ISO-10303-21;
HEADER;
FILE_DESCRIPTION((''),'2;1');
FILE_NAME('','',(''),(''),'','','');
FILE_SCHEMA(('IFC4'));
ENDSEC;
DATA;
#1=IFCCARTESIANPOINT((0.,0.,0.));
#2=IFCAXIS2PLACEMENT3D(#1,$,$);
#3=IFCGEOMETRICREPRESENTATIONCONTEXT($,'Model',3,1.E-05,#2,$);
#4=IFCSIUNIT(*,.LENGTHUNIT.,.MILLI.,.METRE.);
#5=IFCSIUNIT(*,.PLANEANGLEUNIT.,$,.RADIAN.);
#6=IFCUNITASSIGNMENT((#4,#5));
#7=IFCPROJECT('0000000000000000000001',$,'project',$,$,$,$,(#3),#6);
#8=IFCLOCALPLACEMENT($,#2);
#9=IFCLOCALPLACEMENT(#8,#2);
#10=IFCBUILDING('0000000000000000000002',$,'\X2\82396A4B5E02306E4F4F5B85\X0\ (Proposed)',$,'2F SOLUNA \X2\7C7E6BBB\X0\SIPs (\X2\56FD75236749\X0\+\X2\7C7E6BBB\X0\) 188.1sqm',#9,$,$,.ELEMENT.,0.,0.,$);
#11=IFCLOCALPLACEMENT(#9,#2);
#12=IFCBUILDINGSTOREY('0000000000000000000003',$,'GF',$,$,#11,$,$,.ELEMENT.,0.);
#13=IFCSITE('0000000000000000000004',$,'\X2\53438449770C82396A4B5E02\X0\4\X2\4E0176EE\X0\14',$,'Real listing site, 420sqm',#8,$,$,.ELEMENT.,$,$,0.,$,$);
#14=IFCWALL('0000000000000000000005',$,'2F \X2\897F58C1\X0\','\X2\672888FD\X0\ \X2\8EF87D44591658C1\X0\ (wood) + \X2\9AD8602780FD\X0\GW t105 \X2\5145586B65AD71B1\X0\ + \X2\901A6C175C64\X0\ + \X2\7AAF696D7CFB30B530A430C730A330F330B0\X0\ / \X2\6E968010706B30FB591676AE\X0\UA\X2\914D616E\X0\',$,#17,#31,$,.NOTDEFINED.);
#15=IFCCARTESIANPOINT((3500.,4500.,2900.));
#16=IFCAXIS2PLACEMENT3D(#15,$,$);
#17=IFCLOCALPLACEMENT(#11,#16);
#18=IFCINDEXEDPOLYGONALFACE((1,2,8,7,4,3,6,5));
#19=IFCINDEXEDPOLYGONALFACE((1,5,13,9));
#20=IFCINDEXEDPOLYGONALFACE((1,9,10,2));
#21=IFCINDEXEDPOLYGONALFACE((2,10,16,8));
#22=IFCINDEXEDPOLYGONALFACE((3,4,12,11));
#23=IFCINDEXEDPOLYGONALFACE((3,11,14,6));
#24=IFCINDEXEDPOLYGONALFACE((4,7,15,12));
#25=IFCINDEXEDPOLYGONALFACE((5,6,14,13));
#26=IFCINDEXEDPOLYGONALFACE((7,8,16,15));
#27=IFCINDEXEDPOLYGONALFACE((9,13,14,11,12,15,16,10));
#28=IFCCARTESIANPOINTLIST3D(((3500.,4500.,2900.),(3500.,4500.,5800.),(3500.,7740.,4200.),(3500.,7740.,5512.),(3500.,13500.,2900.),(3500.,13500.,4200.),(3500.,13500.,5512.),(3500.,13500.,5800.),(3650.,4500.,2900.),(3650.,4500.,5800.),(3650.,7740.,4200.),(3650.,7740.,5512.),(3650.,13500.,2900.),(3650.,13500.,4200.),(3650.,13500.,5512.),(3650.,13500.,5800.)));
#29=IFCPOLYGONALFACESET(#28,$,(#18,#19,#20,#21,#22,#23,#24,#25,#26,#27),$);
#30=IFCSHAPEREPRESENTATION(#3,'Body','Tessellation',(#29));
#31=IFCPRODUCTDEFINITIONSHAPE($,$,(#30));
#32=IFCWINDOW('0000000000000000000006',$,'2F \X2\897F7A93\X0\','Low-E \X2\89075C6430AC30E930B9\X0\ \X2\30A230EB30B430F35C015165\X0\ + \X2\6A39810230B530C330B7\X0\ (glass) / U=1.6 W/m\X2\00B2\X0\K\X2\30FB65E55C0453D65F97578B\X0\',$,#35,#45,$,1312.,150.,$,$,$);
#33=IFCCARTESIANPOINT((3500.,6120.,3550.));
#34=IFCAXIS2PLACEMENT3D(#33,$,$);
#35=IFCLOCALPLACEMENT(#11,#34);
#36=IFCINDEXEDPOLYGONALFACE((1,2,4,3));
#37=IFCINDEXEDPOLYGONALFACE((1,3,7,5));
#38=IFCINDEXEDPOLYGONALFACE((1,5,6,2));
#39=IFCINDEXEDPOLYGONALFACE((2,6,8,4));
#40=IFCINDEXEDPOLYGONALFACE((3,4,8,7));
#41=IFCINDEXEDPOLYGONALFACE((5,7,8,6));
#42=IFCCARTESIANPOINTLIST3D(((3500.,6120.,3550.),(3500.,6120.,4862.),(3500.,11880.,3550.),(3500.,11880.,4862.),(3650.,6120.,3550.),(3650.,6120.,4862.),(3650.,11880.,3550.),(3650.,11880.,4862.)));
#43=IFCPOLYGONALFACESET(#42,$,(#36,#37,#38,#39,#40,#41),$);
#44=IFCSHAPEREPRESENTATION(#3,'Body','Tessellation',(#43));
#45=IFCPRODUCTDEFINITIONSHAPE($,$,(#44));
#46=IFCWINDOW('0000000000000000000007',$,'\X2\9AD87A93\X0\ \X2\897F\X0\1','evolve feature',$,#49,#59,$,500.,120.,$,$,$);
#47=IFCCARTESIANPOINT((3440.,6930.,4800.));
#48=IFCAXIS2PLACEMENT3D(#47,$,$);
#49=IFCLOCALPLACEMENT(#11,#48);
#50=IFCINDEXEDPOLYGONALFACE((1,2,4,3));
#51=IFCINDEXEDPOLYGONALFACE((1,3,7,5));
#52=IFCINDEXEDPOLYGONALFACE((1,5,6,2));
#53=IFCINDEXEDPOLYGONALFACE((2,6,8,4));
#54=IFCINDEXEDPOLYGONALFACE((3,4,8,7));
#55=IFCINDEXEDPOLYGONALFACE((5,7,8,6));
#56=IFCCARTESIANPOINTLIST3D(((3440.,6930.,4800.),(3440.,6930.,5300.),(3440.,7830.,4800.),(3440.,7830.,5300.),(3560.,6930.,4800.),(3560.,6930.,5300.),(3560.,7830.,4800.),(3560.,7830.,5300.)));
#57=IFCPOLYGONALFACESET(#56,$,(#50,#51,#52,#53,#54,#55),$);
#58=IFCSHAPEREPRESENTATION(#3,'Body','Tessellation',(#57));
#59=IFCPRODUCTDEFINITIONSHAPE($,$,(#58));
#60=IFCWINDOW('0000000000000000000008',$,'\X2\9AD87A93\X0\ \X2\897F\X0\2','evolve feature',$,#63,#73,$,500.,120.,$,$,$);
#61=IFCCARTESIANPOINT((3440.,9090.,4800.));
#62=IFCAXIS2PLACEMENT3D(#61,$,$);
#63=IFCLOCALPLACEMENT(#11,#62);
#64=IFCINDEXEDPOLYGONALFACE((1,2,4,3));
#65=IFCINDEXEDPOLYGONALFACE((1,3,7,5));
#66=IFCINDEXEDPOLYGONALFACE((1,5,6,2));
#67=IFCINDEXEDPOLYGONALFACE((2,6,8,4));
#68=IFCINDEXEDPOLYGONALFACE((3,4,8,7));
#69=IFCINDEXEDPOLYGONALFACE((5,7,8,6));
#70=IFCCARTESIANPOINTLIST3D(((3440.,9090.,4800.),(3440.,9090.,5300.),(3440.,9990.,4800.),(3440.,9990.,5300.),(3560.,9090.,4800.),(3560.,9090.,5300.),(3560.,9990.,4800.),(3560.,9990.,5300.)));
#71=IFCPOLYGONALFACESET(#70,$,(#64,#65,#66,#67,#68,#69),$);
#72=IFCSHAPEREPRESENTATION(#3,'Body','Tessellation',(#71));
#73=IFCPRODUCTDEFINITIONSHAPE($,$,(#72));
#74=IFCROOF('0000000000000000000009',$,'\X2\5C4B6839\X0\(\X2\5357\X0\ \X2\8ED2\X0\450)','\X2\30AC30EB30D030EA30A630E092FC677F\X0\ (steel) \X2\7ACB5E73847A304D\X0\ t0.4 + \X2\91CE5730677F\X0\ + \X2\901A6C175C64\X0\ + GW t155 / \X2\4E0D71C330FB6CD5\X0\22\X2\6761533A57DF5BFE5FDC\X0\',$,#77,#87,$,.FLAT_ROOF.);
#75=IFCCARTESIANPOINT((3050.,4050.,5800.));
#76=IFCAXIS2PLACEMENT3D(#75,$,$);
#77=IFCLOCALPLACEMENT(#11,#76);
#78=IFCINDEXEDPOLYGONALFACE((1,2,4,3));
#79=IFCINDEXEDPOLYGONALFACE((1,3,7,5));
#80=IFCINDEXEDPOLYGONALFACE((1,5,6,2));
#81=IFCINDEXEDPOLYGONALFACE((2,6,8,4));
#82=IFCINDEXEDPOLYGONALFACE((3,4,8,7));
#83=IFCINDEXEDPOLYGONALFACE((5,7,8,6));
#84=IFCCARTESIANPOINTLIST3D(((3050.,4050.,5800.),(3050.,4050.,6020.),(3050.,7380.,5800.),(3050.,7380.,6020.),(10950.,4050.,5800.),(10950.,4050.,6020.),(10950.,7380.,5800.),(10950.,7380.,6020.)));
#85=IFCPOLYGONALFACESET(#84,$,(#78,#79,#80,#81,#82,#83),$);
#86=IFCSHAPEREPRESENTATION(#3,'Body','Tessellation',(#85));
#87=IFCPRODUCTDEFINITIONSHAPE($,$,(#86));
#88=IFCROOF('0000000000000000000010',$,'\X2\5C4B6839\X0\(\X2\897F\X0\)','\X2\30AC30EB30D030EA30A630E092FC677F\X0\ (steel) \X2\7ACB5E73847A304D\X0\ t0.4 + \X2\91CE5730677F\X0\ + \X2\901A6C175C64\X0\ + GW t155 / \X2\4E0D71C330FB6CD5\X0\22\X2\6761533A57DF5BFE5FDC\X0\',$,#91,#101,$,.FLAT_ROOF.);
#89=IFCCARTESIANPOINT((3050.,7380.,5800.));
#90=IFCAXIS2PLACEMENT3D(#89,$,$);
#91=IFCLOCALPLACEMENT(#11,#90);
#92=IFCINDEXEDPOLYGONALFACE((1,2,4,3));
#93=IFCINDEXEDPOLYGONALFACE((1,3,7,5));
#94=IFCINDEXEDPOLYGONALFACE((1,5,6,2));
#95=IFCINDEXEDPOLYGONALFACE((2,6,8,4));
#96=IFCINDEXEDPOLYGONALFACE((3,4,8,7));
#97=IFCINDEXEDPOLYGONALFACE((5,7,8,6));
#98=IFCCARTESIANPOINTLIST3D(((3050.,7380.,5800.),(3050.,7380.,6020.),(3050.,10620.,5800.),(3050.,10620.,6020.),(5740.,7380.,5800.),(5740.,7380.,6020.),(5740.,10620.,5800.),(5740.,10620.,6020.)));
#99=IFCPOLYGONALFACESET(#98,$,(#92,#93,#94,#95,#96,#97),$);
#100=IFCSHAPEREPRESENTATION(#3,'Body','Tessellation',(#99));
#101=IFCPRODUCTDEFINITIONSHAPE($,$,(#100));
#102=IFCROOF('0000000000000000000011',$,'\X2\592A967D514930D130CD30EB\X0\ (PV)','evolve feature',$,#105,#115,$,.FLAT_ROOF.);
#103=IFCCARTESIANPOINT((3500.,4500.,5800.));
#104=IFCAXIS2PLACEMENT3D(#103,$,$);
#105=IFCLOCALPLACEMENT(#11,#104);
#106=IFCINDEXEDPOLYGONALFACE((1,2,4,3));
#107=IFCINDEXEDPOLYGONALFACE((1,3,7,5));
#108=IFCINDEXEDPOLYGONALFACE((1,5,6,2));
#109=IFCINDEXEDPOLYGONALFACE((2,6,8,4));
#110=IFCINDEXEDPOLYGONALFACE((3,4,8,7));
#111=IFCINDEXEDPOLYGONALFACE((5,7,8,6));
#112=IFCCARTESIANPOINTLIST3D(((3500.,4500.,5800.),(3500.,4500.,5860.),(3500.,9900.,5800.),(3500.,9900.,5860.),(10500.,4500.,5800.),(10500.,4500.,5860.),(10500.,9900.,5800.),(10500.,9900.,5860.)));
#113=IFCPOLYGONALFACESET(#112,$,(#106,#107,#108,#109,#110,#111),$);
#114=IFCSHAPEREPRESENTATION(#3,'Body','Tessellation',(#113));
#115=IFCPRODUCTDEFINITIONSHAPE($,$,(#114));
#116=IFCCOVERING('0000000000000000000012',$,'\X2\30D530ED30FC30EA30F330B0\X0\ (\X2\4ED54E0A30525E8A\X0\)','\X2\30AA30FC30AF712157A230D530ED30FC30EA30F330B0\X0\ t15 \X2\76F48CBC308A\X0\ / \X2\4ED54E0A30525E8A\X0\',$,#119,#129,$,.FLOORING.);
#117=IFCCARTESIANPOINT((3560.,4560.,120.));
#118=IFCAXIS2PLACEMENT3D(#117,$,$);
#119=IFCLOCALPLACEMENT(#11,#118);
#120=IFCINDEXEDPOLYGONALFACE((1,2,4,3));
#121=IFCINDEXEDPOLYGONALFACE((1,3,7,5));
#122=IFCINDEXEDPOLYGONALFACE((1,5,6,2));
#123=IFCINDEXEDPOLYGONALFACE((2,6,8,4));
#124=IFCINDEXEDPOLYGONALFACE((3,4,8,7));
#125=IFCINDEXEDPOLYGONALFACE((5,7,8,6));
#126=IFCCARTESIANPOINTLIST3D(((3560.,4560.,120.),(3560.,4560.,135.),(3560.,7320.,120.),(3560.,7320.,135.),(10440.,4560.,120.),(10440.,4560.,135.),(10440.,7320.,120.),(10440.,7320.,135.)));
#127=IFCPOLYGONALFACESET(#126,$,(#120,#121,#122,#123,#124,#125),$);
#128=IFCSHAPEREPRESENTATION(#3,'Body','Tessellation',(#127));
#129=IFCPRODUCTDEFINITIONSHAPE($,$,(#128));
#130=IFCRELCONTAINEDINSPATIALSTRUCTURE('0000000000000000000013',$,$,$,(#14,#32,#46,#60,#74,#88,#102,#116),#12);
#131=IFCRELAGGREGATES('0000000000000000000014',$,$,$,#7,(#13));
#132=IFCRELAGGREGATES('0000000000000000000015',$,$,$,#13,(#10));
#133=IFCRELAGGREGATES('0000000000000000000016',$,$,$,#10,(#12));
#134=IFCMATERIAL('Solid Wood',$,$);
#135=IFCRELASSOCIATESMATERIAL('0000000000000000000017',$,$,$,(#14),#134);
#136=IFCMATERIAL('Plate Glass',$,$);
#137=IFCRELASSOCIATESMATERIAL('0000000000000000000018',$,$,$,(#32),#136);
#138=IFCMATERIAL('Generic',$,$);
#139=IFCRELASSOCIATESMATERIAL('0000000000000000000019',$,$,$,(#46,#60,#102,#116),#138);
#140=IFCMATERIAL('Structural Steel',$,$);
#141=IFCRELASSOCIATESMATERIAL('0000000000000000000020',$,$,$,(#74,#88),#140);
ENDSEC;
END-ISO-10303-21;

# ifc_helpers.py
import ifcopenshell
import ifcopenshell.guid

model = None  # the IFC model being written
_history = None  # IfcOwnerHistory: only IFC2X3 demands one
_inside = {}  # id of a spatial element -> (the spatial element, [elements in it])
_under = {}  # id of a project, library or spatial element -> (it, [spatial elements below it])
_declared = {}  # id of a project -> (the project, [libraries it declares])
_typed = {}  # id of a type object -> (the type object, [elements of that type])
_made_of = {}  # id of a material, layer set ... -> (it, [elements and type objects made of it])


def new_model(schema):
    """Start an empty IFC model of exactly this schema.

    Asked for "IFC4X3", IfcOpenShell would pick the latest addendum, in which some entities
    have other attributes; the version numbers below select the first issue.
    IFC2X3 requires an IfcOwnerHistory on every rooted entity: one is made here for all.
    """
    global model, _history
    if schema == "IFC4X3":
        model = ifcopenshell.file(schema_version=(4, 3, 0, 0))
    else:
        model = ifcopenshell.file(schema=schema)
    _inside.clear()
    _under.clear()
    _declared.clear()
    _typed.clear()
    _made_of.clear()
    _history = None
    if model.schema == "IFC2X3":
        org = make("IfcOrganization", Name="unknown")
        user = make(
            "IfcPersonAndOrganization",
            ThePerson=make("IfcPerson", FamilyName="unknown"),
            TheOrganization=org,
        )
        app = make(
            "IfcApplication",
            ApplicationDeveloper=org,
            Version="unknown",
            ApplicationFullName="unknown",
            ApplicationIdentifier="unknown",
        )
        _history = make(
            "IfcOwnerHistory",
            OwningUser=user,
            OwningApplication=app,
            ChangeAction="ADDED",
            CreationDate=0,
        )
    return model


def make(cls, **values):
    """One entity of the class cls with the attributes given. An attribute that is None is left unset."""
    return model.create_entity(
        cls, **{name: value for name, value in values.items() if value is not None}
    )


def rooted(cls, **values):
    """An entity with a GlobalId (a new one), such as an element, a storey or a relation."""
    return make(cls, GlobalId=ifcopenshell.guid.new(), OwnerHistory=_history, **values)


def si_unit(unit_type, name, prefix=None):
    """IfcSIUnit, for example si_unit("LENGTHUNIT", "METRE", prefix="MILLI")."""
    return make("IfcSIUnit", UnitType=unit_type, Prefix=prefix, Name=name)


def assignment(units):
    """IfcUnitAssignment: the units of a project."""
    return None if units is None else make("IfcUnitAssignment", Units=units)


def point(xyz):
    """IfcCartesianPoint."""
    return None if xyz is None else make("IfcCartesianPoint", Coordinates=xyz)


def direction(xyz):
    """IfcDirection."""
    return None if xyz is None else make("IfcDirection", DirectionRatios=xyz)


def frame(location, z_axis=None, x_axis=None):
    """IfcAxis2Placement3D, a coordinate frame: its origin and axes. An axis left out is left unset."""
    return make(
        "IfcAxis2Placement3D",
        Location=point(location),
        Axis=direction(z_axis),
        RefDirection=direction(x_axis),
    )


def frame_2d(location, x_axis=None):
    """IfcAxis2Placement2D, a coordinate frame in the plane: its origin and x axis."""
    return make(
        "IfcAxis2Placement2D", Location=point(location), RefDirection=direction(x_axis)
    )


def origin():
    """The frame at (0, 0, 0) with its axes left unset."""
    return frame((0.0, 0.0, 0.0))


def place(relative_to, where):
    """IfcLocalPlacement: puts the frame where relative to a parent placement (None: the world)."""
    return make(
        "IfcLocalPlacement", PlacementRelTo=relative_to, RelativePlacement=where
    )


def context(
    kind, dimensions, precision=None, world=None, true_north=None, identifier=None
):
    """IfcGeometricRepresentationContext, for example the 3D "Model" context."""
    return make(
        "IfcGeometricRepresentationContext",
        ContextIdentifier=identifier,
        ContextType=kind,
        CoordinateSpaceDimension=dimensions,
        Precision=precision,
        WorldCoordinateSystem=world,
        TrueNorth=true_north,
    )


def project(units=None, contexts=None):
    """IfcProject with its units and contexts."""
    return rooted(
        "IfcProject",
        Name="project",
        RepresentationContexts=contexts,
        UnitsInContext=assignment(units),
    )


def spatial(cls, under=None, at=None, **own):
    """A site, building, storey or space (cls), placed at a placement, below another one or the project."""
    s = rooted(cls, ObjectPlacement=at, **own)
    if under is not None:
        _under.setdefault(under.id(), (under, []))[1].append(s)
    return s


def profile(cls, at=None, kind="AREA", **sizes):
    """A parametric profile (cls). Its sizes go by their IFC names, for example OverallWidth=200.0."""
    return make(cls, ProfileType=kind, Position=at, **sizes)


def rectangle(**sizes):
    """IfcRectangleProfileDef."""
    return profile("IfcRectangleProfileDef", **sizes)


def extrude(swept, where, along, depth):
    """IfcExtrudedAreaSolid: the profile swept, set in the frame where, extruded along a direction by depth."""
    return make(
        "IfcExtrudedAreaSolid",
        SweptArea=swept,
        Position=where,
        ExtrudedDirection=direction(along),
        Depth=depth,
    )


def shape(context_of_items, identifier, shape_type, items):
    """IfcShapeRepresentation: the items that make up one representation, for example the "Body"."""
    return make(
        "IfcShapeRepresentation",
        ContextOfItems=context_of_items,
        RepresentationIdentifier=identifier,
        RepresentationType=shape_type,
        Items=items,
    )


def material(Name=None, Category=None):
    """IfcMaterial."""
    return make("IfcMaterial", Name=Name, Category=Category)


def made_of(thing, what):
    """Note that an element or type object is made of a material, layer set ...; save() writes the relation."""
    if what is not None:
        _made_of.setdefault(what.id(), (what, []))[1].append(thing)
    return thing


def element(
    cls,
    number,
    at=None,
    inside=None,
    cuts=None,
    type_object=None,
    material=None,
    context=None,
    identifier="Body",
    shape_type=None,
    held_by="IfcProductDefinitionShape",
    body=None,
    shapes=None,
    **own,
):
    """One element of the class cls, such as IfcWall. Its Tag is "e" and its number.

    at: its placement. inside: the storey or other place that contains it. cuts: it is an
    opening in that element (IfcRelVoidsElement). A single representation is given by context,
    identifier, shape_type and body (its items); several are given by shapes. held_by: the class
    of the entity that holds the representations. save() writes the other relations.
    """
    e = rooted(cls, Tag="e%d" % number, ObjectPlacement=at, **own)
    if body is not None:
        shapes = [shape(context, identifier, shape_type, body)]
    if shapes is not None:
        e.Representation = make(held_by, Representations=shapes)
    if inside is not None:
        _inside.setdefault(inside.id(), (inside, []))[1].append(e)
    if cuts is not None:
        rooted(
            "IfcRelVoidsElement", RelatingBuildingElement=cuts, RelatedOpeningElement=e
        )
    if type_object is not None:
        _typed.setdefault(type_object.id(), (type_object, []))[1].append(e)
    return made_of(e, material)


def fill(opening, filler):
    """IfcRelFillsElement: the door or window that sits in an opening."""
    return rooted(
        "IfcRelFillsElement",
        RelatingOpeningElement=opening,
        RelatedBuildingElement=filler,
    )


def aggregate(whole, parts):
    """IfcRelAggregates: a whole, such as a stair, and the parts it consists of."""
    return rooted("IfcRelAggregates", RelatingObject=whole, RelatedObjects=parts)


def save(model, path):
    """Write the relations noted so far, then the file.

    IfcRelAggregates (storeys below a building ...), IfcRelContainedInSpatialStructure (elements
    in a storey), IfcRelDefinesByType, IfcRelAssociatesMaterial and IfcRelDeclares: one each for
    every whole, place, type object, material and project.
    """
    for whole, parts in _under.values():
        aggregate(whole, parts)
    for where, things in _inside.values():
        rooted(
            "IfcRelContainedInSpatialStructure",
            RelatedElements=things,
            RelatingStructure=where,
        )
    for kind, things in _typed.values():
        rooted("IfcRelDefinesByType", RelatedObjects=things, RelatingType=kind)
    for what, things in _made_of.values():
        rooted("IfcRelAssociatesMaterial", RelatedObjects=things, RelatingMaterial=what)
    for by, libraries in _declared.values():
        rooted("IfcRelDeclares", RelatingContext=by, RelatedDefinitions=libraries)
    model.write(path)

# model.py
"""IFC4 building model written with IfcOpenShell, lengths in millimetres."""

from ifc_helpers import new_model, si_unit, frame, frame_2d, origin, place, context, project, spatial, rectangle, extrude, material, element, fill, save


model = new_model("IFC4")

# Units and contexts
model_context = context("Model", 3, precision=1e-05, world=origin())
ifc_project = project(units=[si_unit("LENGTHUNIT", "METRE", prefix="MILLI"), si_unit("PLANEANGLEUNIT", "RADIAN")], contexts=[model_context])

# Site, building, storey
site_placement = place(None, origin())
site = spatial("IfcSite", under=ifc_project, at=site_placement, Name="千葉県船橋市4丁目14", ObjectType="Real listing site, 420sqm", CompositionType="ELEMENT", RefElevation=0.0)
building_placement = place(site_placement, origin())
building = spatial("IfcBuilding", under=site, at=building_placement, Name="船橋市の住宅 (Proposed)", ObjectType="2F SOLUNA 籾殻SIPs (国産杉+籾殻) 188.1sqm", CompositionType="ELEMENT", ElevationOfRefHeight=0.0, ElevationOfTerrain=0.0)
storey_placement = place(building_placement, origin())
storey = spatial("IfcBuildingStorey", under=building, at=storey_placement, Name="GF", CompositionType="ELEMENT", Elevation=0.0)

# Shared definitions
ifc_material_1 = material(Name="Solid Wood")
ifc_material_2 = material(Name="Generic")

# Shared definitions
ifc_material_3 = material(Name="Plate Glass")

# Wall, openings, windows
wall_1_placement = place(storey_placement, frame((3500.0, 4500.0, 2900.0)))
wall_1 = element("IfcWall", 1, at=wall_1_placement, inside=storey, material=ifc_material_1, Name="2F 西壁", Description="木製 軸組外壁 (wood) + 高性能GW t105 充填断熱 + 通気層 + 窯業系サイディング / 準耐火・外皮UA配慮", PredefinedType="NOTDEFINED", context=model_context, shape_type="SweptSolid", body=[
    extrude(rectangle(XDim=150.0, YDim=9000.0, at=frame_2d((75.0, 4500.0))), frame((3500.0, 4500.0, 2900.0)), (0.0, 0.0, 1.0), 2900.0),
])
opening_1_placement = place(storey_placement, frame((3500.0, 6120.0, 3550.0)))
opening_1 = element("IfcOpeningElement", 2, at=opening_1_placement, cuts=wall_1, PredefinedType="NOTDEFINED", context=model_context, shape_type="SweptSolid", body=[
    extrude(rectangle(XDim=150.0, YDim=5760.0, at=frame_2d((75.0, 2880.0))), frame((3500.0, 6120.0, 3550.0)), (0.0, 0.0, 1.0), 1312.0),
])
opening_2_placement = place(storey_placement, frame((3440.0, 6930.0, 4800.0)))
opening_2 = element("IfcOpeningElement", 3, at=opening_2_placement, cuts=wall_1, PredefinedType="NOTDEFINED", context=model_context, shape_type="SweptSolid", body=[
    extrude(rectangle(XDim=120.0, YDim=900.0, at=frame_2d((60.0, 450.0))), frame((3440.0, 6930.0, 4800.0)), (0.0, 0.0, 1.0), 500.0),
])
opening_3_placement = place(storey_placement, frame((3440.0, 9090.0, 4800.0)))
opening_3 = element("IfcOpeningElement", 4, at=opening_3_placement, cuts=wall_1, PredefinedType="NOTDEFINED", context=model_context, shape_type="SweptSolid", body=[
    extrude(rectangle(XDim=120.0, YDim=900.0, at=frame_2d((60.0, 450.0))), frame((3440.0, 9090.0, 4800.0)), (0.0, 0.0, 1.0), 500.0),
])
window_1_placement = place(storey_placement, frame((3500.0, 6120.0, 3550.0)))
window_1 = element("IfcWindow", 5, at=window_1_placement, inside=storey, material=ifc_material_3, Name="2F 西窓", Description="Low-E 複層ガラス アルゴン封入 + 樹脂サッシ (glass) / U=1.6 W/m²K・日射取得型", OverallHeight=1312.0, OverallWidth=150.0, context=model_context, shape_type="SweptSolid", body=[
    extrude(rectangle(XDim=150.0, YDim=5760.0, at=frame_2d((75.0, 2880.0))), frame((3500.0, 6120.0, 3550.0)), (0.0, 0.0, 1.0), 1312.0),
])
fill(opening_1, window_1)
window_2_placement = place(storey_placement, frame((3440.0, 6930.0, 4800.0)))
window_2 = element("IfcWindow", 6, at=window_2_placement, inside=storey, material=ifc_material_2, Name="高窓 西1", Description="evolve feature", OverallHeight=500.0, OverallWidth=120.0, context=model_context, shape_type="SweptSolid", body=[
    extrude(rectangle(XDim=120.0, YDim=900.0, at=frame_2d((60.0, 450.0))), frame((3440.0, 6930.0, 4800.0)), (0.0, 0.0, 1.0), 500.0),
])
fill(opening_2, window_2)
window_3_placement = place(storey_placement, frame((3440.0, 9090.0, 4800.0)))
window_3 = element("IfcWindow", 7, at=window_3_placement, inside=storey, material=ifc_material_2, Name="高窓 西2", Description="evolve feature", OverallHeight=500.0, OverallWidth=120.0, context=model_context, shape_type="SweptSolid", body=[
    extrude(rectangle(XDim=120.0, YDim=900.0, at=frame_2d((60.0, 450.0))), frame((3440.0, 9090.0, 4800.0)), (0.0, 0.0, 1.0), 500.0),
])
fill(opening_3, window_3)

# Roofs
ifc_material_4 = material(Name="Structural Steel")
roof_1_placement = place(storey_placement, frame((3050.0, 4050.0, 5800.0)))
element("IfcRoof", 8, at=roof_1_placement, inside=storey, material=ifc_material_4, Name="屋根(南 軒450)", Description="ガルバリウム鋼板 (steel) 立平葺き t0.4 + 野地板 + 通気層 + GW t155 / 不燃・法22条区域対応", PredefinedType="FLAT_ROOF", context=model_context, shape_type="SweptSolid", body=[
    extrude(rectangle(XDim=7900.0, YDim=3330.0, at=frame_2d((3950.0, 1665.0))), frame((3050.0, 4050.0, 5800.0)), (0.0, 0.0, 1.0), 220.0),
])
roof_2_placement = place(storey_placement, frame((3050.0, 7380.0, 5800.0)))
element("IfcRoof", 9, at=roof_2_placement, inside=storey, material=ifc_material_4, Name="屋根(西)", Description="ガルバリウム鋼板 (steel) 立平葺き t0.4 + 野地板 + 通気層 + GW t155 / 不燃・法22条区域対応", PredefinedType="FLAT_ROOF", context=model_context, shape_type="SweptSolid", body=[
    extrude(rectangle(XDim=2690.0, YDim=3240.0, at=frame_2d((1345.0, 1620.0))), frame((3050.0, 7380.0, 5800.0)), (0.0, 0.0, 1.0), 220.0),
])
roof_3_placement = place(storey_placement, frame((3500.0, 4500.0, 5800.0)))
element("IfcRoof", 10, at=roof_3_placement, inside=storey, material=ifc_material_2, Name="太陽光パネル (PV)", Description="evolve feature", PredefinedType="FLAT_ROOF", context=model_context, shape_type="SweptSolid", body=[
    extrude(rectangle(XDim=7000.0, YDim=5400.0, at=frame_2d((3500.0, 2700.0))), frame((3500.0, 4500.0, 5800.0)), (0.0, 0.0, 1.0), 60.0),
])

# Covering
covering_placement = place(storey_placement, frame((3560.0, 4560.0, 120.0)))
element("IfcCovering", 11, at=covering_placement, inside=storey, material=ifc_material_2, Name="フローリング (仕上げ床)", Description="オーク無垢フローリング t15 直貼り / 仕上げ床", PredefinedType="FLOORING", context=model_context, shape_type="SweptSolid", body=[
    extrude(rectangle(XDim=6880.0, YDim=2760.0, at=frame_2d((3440.0, 1380.0))), frame((3560.0, 4560.0, 120.0)), (0.0, 0.0, 1.0), 15.0),
])

save(model, "model.ifc")
